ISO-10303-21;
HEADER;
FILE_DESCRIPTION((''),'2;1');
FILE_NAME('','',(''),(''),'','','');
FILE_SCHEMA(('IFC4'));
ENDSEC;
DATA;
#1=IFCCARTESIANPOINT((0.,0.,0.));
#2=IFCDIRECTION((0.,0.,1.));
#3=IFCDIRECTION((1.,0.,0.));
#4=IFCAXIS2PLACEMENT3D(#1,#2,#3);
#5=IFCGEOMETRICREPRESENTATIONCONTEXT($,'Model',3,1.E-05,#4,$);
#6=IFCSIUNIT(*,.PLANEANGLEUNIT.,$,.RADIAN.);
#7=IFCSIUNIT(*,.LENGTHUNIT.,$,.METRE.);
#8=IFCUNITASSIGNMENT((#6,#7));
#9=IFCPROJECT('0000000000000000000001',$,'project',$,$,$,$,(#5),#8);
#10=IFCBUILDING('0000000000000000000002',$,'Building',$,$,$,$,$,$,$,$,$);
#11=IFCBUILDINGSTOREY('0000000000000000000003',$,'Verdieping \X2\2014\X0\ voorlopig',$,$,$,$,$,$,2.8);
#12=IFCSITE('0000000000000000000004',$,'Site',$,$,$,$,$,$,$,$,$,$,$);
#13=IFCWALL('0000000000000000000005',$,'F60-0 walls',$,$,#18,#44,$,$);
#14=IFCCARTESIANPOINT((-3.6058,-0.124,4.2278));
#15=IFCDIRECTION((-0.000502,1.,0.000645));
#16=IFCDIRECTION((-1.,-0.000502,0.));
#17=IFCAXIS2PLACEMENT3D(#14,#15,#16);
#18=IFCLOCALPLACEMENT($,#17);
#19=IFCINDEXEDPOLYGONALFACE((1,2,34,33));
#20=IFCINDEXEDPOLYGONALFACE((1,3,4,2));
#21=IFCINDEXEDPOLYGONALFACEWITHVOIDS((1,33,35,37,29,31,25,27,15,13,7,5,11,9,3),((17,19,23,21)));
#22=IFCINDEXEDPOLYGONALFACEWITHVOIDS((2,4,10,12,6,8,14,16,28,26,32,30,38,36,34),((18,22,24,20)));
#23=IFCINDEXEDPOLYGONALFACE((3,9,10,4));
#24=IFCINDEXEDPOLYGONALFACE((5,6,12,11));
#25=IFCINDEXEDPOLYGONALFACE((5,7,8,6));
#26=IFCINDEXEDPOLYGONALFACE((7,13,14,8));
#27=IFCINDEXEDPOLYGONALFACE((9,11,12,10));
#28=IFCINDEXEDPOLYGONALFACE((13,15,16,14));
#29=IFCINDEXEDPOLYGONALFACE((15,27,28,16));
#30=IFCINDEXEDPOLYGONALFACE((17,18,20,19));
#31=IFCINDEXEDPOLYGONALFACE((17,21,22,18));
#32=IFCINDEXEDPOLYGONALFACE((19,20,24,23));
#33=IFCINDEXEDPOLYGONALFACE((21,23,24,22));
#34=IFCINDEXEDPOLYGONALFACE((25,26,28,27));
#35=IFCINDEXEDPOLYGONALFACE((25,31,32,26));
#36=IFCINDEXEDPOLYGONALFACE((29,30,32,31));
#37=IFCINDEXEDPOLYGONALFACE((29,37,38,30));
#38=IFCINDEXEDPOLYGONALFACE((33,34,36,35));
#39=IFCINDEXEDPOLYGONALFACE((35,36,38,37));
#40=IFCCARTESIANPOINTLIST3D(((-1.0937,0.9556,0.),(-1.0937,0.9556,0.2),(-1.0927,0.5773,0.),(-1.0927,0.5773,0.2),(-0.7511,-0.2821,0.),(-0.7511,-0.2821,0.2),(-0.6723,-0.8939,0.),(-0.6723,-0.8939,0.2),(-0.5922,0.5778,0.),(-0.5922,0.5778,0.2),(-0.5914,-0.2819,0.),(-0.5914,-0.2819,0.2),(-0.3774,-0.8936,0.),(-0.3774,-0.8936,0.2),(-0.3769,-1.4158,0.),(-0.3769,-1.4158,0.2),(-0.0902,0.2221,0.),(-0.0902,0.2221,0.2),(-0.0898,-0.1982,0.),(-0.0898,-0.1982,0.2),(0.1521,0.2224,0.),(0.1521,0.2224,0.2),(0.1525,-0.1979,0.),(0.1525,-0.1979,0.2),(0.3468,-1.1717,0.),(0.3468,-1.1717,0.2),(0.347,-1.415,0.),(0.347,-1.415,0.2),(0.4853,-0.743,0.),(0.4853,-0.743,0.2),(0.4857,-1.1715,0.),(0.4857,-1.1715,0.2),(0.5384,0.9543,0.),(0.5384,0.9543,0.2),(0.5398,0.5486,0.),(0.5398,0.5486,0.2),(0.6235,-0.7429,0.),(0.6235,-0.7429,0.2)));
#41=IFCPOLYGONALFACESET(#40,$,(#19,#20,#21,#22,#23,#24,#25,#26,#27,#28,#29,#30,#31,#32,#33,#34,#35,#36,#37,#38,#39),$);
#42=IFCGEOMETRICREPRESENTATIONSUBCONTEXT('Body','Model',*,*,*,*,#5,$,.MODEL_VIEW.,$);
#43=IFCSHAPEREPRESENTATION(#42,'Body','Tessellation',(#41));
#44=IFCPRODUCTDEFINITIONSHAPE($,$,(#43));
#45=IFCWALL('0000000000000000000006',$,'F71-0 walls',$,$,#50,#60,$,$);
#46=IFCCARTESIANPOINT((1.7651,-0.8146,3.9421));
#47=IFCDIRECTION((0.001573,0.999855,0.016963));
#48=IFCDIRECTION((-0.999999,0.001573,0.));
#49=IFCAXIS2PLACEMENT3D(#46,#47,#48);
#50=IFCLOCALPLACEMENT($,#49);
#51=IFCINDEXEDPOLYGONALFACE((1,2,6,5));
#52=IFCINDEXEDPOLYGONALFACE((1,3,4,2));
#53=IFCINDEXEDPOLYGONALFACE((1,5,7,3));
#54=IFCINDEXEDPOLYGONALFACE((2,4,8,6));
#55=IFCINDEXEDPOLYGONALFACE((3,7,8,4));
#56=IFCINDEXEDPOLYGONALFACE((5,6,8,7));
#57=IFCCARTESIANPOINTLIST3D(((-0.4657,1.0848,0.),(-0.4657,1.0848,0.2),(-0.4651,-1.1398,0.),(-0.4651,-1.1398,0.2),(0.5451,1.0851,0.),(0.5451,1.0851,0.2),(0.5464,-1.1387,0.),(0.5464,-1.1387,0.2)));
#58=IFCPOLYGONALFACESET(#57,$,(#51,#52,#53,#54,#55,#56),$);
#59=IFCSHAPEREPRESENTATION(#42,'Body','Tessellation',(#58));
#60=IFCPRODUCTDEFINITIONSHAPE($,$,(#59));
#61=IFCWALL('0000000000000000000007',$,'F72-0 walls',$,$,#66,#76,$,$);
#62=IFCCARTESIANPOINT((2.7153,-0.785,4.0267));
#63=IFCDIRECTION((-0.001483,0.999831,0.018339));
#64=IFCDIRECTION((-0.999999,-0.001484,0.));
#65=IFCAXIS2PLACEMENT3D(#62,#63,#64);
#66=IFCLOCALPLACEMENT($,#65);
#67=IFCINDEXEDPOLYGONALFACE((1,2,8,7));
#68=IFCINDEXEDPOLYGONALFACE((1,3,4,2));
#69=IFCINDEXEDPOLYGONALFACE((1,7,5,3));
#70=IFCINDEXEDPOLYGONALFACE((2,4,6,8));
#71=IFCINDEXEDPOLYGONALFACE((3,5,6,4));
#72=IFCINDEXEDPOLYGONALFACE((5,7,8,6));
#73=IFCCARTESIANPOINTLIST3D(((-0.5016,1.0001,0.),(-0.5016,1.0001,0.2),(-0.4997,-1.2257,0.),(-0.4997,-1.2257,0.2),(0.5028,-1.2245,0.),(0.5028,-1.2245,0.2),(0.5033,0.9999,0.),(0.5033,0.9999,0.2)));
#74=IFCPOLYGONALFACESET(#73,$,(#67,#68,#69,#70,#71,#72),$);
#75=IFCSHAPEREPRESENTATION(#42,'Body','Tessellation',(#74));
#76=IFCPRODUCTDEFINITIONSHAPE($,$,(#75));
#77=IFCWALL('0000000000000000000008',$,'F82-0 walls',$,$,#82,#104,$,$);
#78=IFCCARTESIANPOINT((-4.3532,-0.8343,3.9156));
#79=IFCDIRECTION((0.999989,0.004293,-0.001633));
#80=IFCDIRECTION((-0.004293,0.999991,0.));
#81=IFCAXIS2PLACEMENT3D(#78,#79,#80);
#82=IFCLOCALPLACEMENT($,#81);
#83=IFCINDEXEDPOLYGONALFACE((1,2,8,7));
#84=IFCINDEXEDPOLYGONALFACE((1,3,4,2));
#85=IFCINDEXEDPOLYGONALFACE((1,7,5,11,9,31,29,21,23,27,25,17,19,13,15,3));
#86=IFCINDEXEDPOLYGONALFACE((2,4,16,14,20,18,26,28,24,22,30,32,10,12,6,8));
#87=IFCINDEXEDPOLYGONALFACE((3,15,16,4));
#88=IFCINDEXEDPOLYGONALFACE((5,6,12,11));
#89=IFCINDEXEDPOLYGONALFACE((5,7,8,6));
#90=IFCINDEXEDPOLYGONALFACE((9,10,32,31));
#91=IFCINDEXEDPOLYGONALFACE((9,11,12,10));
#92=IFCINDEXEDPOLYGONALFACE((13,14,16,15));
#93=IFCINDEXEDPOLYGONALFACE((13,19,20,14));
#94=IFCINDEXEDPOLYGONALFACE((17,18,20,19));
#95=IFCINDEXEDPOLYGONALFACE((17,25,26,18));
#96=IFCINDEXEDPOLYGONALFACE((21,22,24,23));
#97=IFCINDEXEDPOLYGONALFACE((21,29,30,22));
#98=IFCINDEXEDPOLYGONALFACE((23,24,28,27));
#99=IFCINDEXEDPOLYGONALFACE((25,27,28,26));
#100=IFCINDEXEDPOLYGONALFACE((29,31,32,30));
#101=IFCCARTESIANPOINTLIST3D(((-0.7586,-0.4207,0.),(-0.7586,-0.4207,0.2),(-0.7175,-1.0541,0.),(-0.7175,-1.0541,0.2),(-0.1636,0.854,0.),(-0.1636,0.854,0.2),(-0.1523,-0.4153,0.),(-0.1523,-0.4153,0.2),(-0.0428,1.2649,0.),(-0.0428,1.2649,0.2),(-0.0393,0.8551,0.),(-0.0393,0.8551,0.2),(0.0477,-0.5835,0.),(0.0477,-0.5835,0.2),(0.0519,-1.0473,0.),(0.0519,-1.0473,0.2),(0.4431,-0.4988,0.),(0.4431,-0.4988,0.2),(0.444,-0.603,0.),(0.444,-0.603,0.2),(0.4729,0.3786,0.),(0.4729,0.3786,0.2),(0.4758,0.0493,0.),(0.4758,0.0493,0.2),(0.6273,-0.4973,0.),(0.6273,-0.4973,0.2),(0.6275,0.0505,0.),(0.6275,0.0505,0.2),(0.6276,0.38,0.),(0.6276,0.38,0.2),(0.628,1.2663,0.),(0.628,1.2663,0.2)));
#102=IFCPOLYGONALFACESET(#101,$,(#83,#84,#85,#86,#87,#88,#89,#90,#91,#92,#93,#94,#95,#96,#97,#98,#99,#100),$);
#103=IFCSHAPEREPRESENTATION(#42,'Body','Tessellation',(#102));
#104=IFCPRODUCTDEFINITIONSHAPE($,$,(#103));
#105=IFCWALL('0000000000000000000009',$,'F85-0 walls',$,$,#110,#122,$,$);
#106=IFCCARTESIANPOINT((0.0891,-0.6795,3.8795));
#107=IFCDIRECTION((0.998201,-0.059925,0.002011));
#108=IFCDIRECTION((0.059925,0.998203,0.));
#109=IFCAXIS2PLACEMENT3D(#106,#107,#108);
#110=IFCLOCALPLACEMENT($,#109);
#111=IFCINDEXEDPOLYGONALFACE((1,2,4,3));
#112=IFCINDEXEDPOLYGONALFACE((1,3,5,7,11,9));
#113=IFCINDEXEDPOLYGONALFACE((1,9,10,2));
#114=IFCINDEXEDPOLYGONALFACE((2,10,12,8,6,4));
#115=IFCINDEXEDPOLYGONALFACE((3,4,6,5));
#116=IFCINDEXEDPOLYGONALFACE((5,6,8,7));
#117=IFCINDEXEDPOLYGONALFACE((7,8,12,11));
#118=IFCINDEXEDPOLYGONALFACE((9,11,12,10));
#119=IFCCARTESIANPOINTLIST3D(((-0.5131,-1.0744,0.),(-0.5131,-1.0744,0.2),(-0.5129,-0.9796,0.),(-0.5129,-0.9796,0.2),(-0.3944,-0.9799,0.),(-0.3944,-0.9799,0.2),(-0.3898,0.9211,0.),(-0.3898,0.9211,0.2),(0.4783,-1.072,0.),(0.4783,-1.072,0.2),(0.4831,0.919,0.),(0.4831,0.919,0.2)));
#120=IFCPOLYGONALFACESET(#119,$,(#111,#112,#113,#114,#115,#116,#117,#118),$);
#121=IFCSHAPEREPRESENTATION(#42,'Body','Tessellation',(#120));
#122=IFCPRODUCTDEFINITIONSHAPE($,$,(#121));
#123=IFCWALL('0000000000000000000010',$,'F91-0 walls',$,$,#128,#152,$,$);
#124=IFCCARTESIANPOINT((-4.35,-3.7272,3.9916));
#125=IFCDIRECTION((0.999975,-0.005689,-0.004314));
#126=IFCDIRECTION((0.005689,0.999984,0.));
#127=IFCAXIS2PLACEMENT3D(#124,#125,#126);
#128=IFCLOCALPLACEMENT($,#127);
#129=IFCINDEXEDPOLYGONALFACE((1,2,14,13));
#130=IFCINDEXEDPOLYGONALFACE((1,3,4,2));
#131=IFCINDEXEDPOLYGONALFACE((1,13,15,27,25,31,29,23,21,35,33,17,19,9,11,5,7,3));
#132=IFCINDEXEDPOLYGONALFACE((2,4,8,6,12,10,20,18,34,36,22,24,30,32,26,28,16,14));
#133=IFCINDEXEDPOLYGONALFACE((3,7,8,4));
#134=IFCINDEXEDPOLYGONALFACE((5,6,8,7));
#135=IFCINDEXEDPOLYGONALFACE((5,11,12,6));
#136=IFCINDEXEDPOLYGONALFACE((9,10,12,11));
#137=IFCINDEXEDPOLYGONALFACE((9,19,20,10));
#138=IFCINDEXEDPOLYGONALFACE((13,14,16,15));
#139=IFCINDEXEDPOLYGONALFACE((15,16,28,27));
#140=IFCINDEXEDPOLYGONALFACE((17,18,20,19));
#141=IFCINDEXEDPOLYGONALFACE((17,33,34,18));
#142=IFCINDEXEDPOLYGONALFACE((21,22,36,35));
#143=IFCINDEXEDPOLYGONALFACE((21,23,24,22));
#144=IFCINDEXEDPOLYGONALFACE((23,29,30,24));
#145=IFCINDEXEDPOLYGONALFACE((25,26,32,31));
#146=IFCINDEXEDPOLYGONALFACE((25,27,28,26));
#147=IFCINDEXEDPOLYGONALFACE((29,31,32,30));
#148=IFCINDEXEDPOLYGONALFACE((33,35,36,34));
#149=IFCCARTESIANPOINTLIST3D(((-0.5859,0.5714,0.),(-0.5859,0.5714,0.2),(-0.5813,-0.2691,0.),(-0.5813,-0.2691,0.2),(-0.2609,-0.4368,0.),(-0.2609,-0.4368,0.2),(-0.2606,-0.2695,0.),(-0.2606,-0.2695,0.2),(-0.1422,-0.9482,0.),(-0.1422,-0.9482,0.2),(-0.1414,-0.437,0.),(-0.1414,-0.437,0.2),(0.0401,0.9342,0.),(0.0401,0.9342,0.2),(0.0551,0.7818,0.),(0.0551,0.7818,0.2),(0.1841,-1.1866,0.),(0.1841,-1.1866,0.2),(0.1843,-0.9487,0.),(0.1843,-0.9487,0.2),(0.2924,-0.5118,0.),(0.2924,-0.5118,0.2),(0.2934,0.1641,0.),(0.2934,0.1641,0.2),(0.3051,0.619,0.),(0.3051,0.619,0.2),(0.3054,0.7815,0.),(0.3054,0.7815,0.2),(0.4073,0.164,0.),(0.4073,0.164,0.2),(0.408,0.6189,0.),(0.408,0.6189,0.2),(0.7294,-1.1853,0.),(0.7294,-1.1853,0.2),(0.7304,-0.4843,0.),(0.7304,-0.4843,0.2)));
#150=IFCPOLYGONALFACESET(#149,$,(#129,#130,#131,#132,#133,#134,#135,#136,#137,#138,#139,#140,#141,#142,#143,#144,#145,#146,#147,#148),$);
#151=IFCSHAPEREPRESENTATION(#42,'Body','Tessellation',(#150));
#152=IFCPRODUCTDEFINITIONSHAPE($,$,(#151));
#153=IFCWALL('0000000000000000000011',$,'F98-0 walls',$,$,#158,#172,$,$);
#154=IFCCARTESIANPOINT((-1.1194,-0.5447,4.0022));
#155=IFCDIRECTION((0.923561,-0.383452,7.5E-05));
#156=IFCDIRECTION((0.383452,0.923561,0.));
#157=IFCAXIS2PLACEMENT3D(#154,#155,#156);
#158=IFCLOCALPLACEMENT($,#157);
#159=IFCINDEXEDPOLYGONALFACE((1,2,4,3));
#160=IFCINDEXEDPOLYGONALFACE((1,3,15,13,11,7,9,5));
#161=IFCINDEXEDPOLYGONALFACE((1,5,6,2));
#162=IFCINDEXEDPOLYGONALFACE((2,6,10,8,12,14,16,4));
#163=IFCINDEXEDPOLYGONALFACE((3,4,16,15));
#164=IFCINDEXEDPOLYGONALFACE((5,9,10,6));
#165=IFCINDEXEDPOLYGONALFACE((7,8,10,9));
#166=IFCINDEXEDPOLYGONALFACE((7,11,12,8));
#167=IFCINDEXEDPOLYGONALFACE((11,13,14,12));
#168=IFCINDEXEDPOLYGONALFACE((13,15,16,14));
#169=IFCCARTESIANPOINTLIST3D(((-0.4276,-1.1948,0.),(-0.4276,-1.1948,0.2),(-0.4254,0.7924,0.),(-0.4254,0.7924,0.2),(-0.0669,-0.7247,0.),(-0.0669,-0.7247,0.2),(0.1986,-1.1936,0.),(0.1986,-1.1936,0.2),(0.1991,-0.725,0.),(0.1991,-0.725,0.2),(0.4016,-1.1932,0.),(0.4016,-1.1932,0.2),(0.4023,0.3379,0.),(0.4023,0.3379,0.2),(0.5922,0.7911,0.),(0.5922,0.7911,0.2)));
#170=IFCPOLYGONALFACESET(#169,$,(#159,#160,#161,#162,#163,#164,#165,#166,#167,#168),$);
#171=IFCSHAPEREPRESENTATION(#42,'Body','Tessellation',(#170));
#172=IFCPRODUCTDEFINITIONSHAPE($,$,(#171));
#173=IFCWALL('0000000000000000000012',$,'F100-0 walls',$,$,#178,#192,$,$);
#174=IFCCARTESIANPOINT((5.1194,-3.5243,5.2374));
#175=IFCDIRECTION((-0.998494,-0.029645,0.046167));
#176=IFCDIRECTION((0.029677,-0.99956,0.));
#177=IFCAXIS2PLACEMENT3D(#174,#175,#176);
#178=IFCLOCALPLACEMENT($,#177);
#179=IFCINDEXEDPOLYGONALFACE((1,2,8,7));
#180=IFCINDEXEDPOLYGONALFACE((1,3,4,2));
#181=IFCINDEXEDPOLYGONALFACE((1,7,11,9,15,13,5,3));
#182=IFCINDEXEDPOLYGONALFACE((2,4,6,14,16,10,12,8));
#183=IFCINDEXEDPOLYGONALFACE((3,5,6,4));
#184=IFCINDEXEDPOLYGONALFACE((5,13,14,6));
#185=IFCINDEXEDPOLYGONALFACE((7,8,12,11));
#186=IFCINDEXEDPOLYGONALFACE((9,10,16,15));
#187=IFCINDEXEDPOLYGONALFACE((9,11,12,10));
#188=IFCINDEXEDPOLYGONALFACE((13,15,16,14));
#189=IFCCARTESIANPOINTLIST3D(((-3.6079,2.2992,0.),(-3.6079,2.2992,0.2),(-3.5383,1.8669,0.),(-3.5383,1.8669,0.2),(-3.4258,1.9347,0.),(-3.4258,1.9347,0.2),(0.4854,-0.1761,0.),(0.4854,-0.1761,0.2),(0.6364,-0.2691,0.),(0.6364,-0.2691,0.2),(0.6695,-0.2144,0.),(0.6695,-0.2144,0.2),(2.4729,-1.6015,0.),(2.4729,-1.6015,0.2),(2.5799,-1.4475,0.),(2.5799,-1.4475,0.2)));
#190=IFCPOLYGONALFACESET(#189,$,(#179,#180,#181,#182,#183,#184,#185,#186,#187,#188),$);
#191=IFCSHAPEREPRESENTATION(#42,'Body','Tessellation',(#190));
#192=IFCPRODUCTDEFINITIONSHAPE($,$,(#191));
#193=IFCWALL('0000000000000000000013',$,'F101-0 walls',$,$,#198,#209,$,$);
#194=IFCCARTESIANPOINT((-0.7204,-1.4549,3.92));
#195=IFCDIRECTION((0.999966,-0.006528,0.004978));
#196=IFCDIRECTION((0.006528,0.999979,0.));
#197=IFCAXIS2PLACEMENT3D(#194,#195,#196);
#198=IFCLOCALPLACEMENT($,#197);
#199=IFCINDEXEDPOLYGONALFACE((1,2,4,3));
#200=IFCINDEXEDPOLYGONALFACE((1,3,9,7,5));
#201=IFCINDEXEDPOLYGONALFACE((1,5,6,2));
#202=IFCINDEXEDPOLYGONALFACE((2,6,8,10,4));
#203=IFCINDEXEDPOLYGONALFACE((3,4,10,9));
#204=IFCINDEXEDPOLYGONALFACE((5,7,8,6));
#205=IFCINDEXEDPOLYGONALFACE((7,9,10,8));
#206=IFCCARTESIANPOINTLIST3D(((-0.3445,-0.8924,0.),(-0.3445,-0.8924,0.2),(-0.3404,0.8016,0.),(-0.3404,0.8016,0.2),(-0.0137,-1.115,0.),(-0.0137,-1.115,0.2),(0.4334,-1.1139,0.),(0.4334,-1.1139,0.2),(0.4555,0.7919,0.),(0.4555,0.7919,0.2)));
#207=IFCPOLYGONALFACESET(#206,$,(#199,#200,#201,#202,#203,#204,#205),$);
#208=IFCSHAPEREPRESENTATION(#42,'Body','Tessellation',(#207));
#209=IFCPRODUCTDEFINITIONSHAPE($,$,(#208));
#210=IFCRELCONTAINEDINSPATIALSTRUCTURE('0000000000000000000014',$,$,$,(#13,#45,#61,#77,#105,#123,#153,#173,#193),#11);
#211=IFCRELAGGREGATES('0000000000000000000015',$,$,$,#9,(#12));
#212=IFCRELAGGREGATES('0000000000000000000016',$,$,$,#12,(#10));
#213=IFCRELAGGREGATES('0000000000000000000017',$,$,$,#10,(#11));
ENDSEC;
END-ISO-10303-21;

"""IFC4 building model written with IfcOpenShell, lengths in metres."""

from ifc_helpers import new_model, si_unit, frame, origin_with_axes, place, context, subcontext, project, spatial, polyline, outline, extrude, element, save


model = new_model("IFC4")

# Units and contexts
model_context = context("Model", 3, precision=1e-05, world=origin_with_axes())
body_context = subcontext(model_context, "Body", "Model", "MODEL_VIEW")
ifc_project = project(units=[si_unit("PLANEANGLEUNIT", "RADIAN"), si_unit("LENGTHUNIT", "METRE")], contexts=[model_context])

# Site, building, storey
site = spatial("IfcSite", under=ifc_project, Name="Site")
building = spatial("IfcBuilding", under=site, Name="Building")
storey = spatial("IfcBuildingStorey", under=building, Name="Verdieping — voorlopig", Elevation=2.8)

# Wall, opening
wall_1_placement = place(None, frame((-3.6058, -0.124, 4.2278), z_axis=(-0.000502, 1.0, 0.000645), x_axis=(-1.0, -0.000502, 0.0)))
wall_1 = element("IfcWall", 1, at=wall_1_placement, inside=storey, Name="F60-0 walls", context=body_context, shape_type="SweptSolid", body=[
    extrude(outline(polyline([(0.347, -1.415), (0.3468, -1.1717), (0.4857, -1.1715), (0.4853, -0.743), (0.6235, -0.7429), (0.5398, 0.5486), (0.5384, 0.9543), (-1.0937, 0.9556), (-1.0927, 0.5773), (-0.5922, 0.5778), (-0.5914, -0.2819), (-0.7511, -0.2821), (-0.6723, -0.8939), (-0.3774, -0.8936), (-0.3769, -1.4158), (0.347, -1.415)])), origin_with_axes(), (0.0, 0.0, 1.0), 0.2),
])
opening_1_placement = place(wall_1_placement, frame((0.0, 0.0, -0.05), z_axis=(0.0, 0.0, 1.0), x_axis=(1.0, 0.0, 0.0)))
element("IfcOpeningElement", 2, at=opening_1_placement, cuts=wall_1, PredefinedType="OPENING", context=body_context, shape_type="SweptSolid", body=[
    extrude(outline(polyline([(-0.0898, -0.1982), (-0.0902, 0.2221), (0.1521, 0.2224), (0.1525, -0.1979), (-0.0898, -0.1982)])), origin_with_axes(), (0.0, 0.0, 1.0), 0.3),
])

# Walls
wall_2_placement = place(None, frame((1.7651, -0.8146, 3.9421), z_axis=(0.001573, 0.999855, 0.016963), x_axis=(-0.999999, 0.001573, 0.0)))
element("IfcWall", 3, at=wall_2_placement, inside=storey, Name="F71-0 walls", context=body_context, shape_type="SweptSolid", body=[
    extrude(outline(polyline([(-0.4651, -1.1398), (0.5464, -1.1387), (0.5451, 1.0851), (-0.4657, 1.0848), (-0.4651, -1.1398)])), origin_with_axes(), (0.0, 0.0, 1.0), 0.2),
])
wall_3_placement = place(None, frame((2.7153, -0.785, 4.0267), z_axis=(-0.001483, 0.999831, 0.018339), x_axis=(-0.999999, -0.001484, 0.0)))
element("IfcWall", 4, at=wall_3_placement, inside=storey, Name="F72-0 walls", context=body_context, shape_type="SweptSolid", body=[
    extrude(outline(polyline([(-0.4997, -1.2257), (0.5028, -1.2245), (0.5033, 0.9999), (-0.5016, 1.0001), (-0.4997, -1.2257)])), origin_with_axes(), (0.0, 0.0, 1.0), 0.2),
])
wall_4_placement = place(None, frame((-4.3532, -0.8343, 3.9156), z_axis=(0.999989, 0.004293, -0.001633), x_axis=(-0.004293, 0.999991, 0.0)))
element("IfcWall", 5, at=wall_4_placement, inside=storey, Name="F82-0 walls", context=body_context, shape_type="SweptSolid", body=[
    extrude(outline(polyline([(-0.7175, -1.0541), (0.0519, -1.0473), (0.0477, -0.5835), (0.444, -0.603), (0.4431, -0.4988), (0.6273, -0.4973), (0.6275, 0.0505), (0.4758, 0.0493), (0.4729, 0.3786), (0.6276, 0.38), (0.628, 1.2663), (-0.0428, 1.2649), (-0.0393, 0.8551), (-0.1636, 0.854), (-0.1523, -0.4153), (-0.7586, -0.4207), (-0.7175, -1.0541)])), origin_with_axes(), (0.0, 0.0, 1.0), 0.2),
])
wall_5_placement = place(None, frame((0.0891, -0.6795, 3.8795), z_axis=(0.998201, -0.059925, 0.002011), x_axis=(0.059925, 0.998203, 0.0)))
element("IfcWall", 6, at=wall_5_placement, inside=storey, Name="F85-0 walls", context=body_context, shape_type="SweptSolid", body=[
    extrude(outline(polyline([(-0.5131, -1.0744), (0.4783, -1.072), (0.4831, 0.919), (-0.3898, 0.9211), (-0.3944, -0.9799), (-0.5129, -0.9796), (-0.5131, -1.0744)])), origin_with_axes(), (0.0, 0.0, 1.0), 0.2),
])
wall_6_placement = place(None, frame((-4.35, -3.7272, 3.9916), z_axis=(0.999975, -0.005689, -0.004314), x_axis=(0.005689, 0.999984, 0.0)))
element("IfcWall", 7, at=wall_6_placement, inside=storey, Name="F91-0 walls", context=body_context, shape_type="SweptSolid", body=[
    extrude(outline(polyline([(0.1841, -1.1866), (0.7294, -1.1853), (0.7304, -0.4843), (0.2924, -0.5118), (0.2934, 0.1641), (0.4073, 0.164), (0.408, 0.6189), (0.3051, 0.619), (0.3054, 0.7815), (0.0551, 0.7818), (0.0401, 0.9342), (-0.5859, 0.5714), (-0.5813, -0.2691), (-0.2606, -0.2695), (-0.2609, -0.4368), (-0.1414, -0.437), (-0.1422, -0.9482), (0.1843, -0.9487), (0.1841, -1.1866)])), origin_with_axes(), (0.0, 0.0, 1.0), 0.2),
])
wall_7_placement = place(None, frame((-1.1194, -0.5447, 4.0022), z_axis=(0.923561, -0.383452, 0.000075), x_axis=(0.383452, 0.923561, 0.0)))
element("IfcWall", 8, at=wall_7_placement, inside=storey, Name="F98-0 walls", context=body_context, shape_type="SweptSolid", body=[
    extrude(outline(polyline([(-0.4276, -1.1948), (-0.0669, -0.7247), (0.1991, -0.725), (0.1986, -1.1936), (0.4016, -1.1932), (0.4023, 0.3379), (0.5922, 0.7911), (-0.4254, 0.7924), (-0.4276, -1.1948)])), origin_with_axes(), (0.0, 0.0, 1.0), 0.2),
])
wall_8_placement = place(None, frame((5.1194, -3.5243, 5.2374), z_axis=(-0.998494, -0.029645, 0.046167), x_axis=(0.029677, -0.99956, 0.0)))
element("IfcWall", 9, at=wall_8_placement, inside=storey, Name="F100-0 walls", context=body_context, shape_type="SweptSolid", body=[
    extrude(outline(polyline([(2.4729, -1.6015), (2.5799, -1.4475), (0.6364, -0.2691), (0.6695, -0.2144), (0.4854, -0.1761), (-3.6079, 2.2992), (-3.5383, 1.8669), (-3.4258, 1.9347), (2.4729, -1.6015)])), origin_with_axes(), (0.0, 0.0, 1.0), 0.2),
])
wall_9_placement = place(None, frame((-0.7204, -1.4549, 3.92), z_axis=(0.999966, -0.006528, 0.004978), x_axis=(0.006528, 0.999979, 0.0)))
element("IfcWall", 10, at=wall_9_placement, inside=storey, Name="F101-0 walls", context=body_context, shape_type="SweptSolid", body=[
    extrude(outline(polyline([(-0.0137, -1.115), (0.4334, -1.1139), (0.4555, 0.7919), (-0.3404, 0.8016), (-0.3445, -0.8924), (-0.0137, -1.115)])), origin_with_axes(), (0.0, 0.0, 1.0), 0.2),
])

save(model, "model.ifc")
